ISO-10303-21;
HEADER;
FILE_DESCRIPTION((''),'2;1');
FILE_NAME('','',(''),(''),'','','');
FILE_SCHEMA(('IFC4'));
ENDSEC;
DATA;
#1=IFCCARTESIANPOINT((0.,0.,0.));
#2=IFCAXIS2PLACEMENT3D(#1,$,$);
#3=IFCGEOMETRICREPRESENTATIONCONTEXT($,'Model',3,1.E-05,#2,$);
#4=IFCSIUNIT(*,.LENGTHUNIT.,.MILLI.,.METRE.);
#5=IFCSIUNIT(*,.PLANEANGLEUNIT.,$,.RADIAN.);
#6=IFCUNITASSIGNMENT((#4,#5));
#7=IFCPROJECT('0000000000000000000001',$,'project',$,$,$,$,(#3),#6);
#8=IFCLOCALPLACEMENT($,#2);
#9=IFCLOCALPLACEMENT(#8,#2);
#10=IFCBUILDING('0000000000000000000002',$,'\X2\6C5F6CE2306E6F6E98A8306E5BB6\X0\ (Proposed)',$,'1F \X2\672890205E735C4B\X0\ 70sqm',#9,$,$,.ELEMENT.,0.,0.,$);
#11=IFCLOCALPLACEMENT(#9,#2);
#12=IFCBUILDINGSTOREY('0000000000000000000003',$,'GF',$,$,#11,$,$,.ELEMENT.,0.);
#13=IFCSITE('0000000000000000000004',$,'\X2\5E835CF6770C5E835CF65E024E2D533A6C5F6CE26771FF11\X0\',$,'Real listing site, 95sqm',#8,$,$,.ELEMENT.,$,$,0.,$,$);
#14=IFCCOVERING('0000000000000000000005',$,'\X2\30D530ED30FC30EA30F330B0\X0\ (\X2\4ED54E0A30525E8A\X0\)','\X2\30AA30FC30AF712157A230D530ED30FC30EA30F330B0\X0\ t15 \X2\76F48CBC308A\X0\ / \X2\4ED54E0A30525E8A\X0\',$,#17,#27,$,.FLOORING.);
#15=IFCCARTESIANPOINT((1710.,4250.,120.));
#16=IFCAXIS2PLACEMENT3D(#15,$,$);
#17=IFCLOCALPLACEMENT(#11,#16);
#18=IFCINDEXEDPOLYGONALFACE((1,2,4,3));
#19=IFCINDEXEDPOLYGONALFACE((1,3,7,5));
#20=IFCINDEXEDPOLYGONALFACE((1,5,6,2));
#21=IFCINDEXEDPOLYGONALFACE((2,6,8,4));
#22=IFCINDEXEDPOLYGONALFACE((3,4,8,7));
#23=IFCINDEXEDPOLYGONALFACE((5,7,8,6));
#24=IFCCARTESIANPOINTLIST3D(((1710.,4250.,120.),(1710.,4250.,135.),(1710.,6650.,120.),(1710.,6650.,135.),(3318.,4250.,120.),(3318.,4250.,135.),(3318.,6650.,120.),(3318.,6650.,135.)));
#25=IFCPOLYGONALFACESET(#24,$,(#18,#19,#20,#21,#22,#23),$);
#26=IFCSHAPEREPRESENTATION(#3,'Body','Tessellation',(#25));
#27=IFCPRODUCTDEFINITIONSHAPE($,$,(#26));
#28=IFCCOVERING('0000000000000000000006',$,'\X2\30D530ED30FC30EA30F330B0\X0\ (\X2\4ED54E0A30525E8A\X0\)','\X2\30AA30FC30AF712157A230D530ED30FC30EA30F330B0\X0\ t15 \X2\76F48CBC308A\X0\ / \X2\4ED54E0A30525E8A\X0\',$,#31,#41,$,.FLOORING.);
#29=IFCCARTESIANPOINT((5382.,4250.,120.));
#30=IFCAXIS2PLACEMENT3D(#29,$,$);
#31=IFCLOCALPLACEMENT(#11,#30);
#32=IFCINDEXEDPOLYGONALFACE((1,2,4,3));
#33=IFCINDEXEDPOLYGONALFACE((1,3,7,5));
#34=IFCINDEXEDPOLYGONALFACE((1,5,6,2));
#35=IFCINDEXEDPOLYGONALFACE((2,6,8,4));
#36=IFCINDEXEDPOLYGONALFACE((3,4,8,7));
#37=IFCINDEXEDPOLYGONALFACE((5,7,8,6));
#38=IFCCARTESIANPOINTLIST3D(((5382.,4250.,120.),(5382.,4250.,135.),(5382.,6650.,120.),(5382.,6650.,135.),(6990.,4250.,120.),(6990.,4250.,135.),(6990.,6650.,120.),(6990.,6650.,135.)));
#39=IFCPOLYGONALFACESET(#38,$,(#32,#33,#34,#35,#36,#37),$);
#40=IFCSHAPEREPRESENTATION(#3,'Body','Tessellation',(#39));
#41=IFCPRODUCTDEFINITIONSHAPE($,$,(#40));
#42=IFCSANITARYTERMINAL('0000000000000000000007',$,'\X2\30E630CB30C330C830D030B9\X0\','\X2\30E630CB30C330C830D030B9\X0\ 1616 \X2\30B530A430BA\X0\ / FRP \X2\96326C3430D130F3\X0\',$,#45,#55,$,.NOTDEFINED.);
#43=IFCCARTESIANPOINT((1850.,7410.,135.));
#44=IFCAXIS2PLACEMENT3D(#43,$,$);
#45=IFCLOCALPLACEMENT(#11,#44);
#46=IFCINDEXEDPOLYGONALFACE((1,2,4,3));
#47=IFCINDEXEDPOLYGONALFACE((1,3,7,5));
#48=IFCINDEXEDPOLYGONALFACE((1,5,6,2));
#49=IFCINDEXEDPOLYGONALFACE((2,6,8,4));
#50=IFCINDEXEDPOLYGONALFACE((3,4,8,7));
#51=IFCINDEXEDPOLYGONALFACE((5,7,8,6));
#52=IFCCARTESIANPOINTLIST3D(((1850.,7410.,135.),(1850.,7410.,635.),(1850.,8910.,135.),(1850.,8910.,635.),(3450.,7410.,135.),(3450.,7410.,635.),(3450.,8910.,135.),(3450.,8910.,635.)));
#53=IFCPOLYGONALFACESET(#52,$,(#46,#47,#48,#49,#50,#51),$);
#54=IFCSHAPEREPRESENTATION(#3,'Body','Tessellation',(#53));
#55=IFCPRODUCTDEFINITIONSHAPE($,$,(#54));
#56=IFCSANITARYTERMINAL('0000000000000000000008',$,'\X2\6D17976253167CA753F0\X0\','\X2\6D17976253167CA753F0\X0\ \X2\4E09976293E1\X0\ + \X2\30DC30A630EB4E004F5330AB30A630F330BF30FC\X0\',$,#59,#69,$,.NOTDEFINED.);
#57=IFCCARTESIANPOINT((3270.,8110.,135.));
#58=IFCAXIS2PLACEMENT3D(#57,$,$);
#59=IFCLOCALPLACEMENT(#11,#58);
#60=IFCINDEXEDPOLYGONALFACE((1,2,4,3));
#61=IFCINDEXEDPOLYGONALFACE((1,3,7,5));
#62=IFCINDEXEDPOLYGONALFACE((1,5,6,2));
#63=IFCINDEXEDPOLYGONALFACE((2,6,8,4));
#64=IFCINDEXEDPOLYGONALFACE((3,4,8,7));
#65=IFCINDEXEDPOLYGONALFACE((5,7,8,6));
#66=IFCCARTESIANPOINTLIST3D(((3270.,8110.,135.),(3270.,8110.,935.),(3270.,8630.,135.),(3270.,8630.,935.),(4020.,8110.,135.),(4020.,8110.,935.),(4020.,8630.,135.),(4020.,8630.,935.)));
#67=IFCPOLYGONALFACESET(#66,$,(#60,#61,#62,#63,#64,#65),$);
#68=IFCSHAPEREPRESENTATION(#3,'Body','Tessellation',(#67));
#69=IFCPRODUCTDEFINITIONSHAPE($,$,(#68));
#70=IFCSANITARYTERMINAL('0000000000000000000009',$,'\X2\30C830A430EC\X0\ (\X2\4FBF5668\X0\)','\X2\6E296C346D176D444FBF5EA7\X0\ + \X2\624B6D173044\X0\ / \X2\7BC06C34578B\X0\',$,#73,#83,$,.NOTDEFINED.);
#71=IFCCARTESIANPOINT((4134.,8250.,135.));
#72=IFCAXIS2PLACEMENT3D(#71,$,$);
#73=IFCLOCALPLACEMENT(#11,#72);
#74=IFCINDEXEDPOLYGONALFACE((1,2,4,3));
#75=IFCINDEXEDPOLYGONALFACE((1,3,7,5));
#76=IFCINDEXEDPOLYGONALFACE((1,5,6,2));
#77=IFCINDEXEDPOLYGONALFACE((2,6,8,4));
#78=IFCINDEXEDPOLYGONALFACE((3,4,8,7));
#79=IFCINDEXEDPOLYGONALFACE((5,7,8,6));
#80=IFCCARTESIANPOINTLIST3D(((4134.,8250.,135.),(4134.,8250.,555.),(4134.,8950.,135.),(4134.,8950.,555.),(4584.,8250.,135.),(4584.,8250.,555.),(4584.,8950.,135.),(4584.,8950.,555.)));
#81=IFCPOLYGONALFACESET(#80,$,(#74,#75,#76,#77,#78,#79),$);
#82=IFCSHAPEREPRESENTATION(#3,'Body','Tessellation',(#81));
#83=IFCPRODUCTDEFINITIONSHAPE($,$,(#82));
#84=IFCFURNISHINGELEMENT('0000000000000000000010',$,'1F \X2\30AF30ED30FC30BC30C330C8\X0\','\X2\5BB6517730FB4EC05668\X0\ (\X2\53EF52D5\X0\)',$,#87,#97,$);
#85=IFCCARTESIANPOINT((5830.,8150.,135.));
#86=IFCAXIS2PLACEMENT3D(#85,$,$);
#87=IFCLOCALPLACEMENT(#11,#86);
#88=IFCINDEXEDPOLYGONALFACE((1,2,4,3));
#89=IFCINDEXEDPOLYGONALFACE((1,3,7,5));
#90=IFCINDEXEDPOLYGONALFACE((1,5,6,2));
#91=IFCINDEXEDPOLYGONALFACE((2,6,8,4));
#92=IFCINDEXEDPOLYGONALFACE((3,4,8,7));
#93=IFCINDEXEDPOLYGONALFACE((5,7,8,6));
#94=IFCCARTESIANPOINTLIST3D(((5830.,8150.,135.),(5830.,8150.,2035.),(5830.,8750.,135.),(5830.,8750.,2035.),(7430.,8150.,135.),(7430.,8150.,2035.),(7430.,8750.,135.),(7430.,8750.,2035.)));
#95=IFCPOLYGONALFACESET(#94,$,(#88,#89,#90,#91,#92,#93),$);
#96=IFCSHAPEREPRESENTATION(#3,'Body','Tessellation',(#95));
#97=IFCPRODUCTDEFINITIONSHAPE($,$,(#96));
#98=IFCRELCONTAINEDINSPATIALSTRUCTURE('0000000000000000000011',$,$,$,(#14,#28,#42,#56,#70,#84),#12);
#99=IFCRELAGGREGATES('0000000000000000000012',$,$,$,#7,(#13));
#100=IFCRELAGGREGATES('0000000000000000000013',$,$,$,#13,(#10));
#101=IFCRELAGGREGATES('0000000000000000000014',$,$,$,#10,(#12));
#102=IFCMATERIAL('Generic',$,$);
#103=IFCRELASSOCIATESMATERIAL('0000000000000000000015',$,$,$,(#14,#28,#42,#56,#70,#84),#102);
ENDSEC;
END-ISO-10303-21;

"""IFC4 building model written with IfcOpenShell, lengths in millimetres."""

from ifc_helpers import new_model, si_unit, frame, frame_2d, origin, place, context, project, spatial, rectangle, extrude, material, element, save


model = new_model("IFC4")

# Units and contexts
model_context = context("Model", 3, precision=1e-05, world=origin())
ifc_project = project(units=[si_unit("LENGTHUNIT", "METRE", prefix="MILLI"), si_unit("PLANEANGLEUNIT", "RADIAN")], contexts=[model_context])

# Site, building, storey
site_placement = place(None, origin())
site = spatial("IfcSite", under=ifc_project, at=site_placement, Name="広島県広島市中区江波東１", ObjectType="Real listing site, 95sqm", CompositionType="ELEMENT", RefElevation=0.0)
building_placement = place(site_placement, origin())
building = spatial("IfcBuilding", under=site, at=building_placement, Name="江波の潮風の家 (Proposed)", ObjectType="1F 木造平屋 70sqm", CompositionType="ELEMENT", ElevationOfRefHeight=0.0, ElevationOfTerrain=0.0)
storey_placement = place(building_placement, origin())
storey = spatial("IfcBuildingStorey", under=building, at=storey_placement, Name="GF", CompositionType="ELEMENT", Elevation=0.0)

# Coverings
ifc_material_1 = material(Name="Generic")
covering_1_placement = place(storey_placement, frame((1710.0, 4250.0, 120.0)))
element("IfcCovering", 1, at=covering_1_placement, inside=storey, material=ifc_material_1, Name="フローリング (仕上げ床)", Description="オーク無垢フローリング t15 直貼り / 仕上げ床", PredefinedType="FLOORING", context=model_context, shape_type="SweptSolid", body=[
    extrude(rectangle(XDim=1608.0, YDim=2400.0, at=frame_2d((804.0, 1200.0))), frame((1710.0, 4250.0, 120.0)), (0.0, 0.0, 1.0), 15.0),
])
covering_2_placement = place(storey_placement, frame((5382.0, 4250.0, 120.0)))
element("IfcCovering", 2, at=covering_2_placement, inside=storey, material=ifc_material_1, Name="フローリング (仕上げ床)", Description="オーク無垢フローリング t15 直貼り / 仕上げ床", PredefinedType="FLOORING", context=model_context, shape_type="SweptSolid", body=[
    extrude(rectangle(XDim=1608.0, YDim=2400.0, at=frame_2d((804.0, 1200.0))), frame((5382.0, 4250.0, 120.0)), (0.0, 0.0, 1.0), 15.0),
])

# Sanitary terminals
sanitary_terminal_1_placement = place(storey_placement, frame((1850.0, 7410.0, 135.0)))
element("IfcSanitaryTerminal", 3, at=sanitary_terminal_1_placement, inside=storey, material=ifc_material_1, Name="ユニットバス", Description="ユニットバス 1616 サイズ / FRP 防水パン", PredefinedType="NOTDEFINED", context=model_context, shape_type="SweptSolid", body=[
    extrude(rectangle(XDim=1600.0, YDim=1500.0, at=frame_2d((800.0, 750.0))), frame((1850.0, 7410.0, 135.0)), (0.0, 0.0, 1.0), 500.0),
])
sanitary_terminal_2_placement = place(storey_placement, frame((3270.0, 8110.0, 135.0)))
element("IfcSanitaryTerminal", 4, at=sanitary_terminal_2_placement, inside=storey, material=ifc_material_1, Name="洗面化粧台", Description="洗面化粧台 三面鏡 + ボウル一体カウンター", PredefinedType="NOTDEFINED", context=model_context, shape_type="SweptSolid", body=[
    extrude(rectangle(XDim=750.0, YDim=520.0, at=frame_2d((375.0, 260.0))), frame((3270.0, 8110.0, 135.0)), (0.0, 0.0, 1.0), 800.0),
])
sanitary_terminal_3_placement = place(storey_placement, frame((4134.0, 8250.0, 135.0)))
element("IfcSanitaryTerminal", 5, at=sanitary_terminal_3_placement, inside=storey, material=ifc_material_1, Name="トイレ (便器)", Description="温水洗浄便座 + 手洗い / 節水型", PredefinedType="NOTDEFINED", context=model_context, shape_type="SweptSolid", body=[
    extrude(rectangle(XDim=450.0, YDim=700.0, at=frame_2d((225.0, 350.0))), frame((4134.0, 8250.0, 135.0)), (0.0, 0.0, 1.0), 420.0),
])

# Furnishing element
furnishing_placement = place(storey_placement, frame((5830.0, 8150.0, 135.0)))
element("IfcFurnishingElement", 6, at=furnishing_placement, inside=storey, material=ifc_material_1, Name="1F クローゼット", Description="家具・什器 (可動)", context=model_context, shape_type="SweptSolid", body=[
    extrude(rectangle(XDim=1600.0, YDim=600.0, at=frame_2d((800.0, 300.0))), frame((5830.0, 8150.0, 135.0)), (0.0, 0.0, 1.0), 1900.0),
])

save(model, "model.ifc")
